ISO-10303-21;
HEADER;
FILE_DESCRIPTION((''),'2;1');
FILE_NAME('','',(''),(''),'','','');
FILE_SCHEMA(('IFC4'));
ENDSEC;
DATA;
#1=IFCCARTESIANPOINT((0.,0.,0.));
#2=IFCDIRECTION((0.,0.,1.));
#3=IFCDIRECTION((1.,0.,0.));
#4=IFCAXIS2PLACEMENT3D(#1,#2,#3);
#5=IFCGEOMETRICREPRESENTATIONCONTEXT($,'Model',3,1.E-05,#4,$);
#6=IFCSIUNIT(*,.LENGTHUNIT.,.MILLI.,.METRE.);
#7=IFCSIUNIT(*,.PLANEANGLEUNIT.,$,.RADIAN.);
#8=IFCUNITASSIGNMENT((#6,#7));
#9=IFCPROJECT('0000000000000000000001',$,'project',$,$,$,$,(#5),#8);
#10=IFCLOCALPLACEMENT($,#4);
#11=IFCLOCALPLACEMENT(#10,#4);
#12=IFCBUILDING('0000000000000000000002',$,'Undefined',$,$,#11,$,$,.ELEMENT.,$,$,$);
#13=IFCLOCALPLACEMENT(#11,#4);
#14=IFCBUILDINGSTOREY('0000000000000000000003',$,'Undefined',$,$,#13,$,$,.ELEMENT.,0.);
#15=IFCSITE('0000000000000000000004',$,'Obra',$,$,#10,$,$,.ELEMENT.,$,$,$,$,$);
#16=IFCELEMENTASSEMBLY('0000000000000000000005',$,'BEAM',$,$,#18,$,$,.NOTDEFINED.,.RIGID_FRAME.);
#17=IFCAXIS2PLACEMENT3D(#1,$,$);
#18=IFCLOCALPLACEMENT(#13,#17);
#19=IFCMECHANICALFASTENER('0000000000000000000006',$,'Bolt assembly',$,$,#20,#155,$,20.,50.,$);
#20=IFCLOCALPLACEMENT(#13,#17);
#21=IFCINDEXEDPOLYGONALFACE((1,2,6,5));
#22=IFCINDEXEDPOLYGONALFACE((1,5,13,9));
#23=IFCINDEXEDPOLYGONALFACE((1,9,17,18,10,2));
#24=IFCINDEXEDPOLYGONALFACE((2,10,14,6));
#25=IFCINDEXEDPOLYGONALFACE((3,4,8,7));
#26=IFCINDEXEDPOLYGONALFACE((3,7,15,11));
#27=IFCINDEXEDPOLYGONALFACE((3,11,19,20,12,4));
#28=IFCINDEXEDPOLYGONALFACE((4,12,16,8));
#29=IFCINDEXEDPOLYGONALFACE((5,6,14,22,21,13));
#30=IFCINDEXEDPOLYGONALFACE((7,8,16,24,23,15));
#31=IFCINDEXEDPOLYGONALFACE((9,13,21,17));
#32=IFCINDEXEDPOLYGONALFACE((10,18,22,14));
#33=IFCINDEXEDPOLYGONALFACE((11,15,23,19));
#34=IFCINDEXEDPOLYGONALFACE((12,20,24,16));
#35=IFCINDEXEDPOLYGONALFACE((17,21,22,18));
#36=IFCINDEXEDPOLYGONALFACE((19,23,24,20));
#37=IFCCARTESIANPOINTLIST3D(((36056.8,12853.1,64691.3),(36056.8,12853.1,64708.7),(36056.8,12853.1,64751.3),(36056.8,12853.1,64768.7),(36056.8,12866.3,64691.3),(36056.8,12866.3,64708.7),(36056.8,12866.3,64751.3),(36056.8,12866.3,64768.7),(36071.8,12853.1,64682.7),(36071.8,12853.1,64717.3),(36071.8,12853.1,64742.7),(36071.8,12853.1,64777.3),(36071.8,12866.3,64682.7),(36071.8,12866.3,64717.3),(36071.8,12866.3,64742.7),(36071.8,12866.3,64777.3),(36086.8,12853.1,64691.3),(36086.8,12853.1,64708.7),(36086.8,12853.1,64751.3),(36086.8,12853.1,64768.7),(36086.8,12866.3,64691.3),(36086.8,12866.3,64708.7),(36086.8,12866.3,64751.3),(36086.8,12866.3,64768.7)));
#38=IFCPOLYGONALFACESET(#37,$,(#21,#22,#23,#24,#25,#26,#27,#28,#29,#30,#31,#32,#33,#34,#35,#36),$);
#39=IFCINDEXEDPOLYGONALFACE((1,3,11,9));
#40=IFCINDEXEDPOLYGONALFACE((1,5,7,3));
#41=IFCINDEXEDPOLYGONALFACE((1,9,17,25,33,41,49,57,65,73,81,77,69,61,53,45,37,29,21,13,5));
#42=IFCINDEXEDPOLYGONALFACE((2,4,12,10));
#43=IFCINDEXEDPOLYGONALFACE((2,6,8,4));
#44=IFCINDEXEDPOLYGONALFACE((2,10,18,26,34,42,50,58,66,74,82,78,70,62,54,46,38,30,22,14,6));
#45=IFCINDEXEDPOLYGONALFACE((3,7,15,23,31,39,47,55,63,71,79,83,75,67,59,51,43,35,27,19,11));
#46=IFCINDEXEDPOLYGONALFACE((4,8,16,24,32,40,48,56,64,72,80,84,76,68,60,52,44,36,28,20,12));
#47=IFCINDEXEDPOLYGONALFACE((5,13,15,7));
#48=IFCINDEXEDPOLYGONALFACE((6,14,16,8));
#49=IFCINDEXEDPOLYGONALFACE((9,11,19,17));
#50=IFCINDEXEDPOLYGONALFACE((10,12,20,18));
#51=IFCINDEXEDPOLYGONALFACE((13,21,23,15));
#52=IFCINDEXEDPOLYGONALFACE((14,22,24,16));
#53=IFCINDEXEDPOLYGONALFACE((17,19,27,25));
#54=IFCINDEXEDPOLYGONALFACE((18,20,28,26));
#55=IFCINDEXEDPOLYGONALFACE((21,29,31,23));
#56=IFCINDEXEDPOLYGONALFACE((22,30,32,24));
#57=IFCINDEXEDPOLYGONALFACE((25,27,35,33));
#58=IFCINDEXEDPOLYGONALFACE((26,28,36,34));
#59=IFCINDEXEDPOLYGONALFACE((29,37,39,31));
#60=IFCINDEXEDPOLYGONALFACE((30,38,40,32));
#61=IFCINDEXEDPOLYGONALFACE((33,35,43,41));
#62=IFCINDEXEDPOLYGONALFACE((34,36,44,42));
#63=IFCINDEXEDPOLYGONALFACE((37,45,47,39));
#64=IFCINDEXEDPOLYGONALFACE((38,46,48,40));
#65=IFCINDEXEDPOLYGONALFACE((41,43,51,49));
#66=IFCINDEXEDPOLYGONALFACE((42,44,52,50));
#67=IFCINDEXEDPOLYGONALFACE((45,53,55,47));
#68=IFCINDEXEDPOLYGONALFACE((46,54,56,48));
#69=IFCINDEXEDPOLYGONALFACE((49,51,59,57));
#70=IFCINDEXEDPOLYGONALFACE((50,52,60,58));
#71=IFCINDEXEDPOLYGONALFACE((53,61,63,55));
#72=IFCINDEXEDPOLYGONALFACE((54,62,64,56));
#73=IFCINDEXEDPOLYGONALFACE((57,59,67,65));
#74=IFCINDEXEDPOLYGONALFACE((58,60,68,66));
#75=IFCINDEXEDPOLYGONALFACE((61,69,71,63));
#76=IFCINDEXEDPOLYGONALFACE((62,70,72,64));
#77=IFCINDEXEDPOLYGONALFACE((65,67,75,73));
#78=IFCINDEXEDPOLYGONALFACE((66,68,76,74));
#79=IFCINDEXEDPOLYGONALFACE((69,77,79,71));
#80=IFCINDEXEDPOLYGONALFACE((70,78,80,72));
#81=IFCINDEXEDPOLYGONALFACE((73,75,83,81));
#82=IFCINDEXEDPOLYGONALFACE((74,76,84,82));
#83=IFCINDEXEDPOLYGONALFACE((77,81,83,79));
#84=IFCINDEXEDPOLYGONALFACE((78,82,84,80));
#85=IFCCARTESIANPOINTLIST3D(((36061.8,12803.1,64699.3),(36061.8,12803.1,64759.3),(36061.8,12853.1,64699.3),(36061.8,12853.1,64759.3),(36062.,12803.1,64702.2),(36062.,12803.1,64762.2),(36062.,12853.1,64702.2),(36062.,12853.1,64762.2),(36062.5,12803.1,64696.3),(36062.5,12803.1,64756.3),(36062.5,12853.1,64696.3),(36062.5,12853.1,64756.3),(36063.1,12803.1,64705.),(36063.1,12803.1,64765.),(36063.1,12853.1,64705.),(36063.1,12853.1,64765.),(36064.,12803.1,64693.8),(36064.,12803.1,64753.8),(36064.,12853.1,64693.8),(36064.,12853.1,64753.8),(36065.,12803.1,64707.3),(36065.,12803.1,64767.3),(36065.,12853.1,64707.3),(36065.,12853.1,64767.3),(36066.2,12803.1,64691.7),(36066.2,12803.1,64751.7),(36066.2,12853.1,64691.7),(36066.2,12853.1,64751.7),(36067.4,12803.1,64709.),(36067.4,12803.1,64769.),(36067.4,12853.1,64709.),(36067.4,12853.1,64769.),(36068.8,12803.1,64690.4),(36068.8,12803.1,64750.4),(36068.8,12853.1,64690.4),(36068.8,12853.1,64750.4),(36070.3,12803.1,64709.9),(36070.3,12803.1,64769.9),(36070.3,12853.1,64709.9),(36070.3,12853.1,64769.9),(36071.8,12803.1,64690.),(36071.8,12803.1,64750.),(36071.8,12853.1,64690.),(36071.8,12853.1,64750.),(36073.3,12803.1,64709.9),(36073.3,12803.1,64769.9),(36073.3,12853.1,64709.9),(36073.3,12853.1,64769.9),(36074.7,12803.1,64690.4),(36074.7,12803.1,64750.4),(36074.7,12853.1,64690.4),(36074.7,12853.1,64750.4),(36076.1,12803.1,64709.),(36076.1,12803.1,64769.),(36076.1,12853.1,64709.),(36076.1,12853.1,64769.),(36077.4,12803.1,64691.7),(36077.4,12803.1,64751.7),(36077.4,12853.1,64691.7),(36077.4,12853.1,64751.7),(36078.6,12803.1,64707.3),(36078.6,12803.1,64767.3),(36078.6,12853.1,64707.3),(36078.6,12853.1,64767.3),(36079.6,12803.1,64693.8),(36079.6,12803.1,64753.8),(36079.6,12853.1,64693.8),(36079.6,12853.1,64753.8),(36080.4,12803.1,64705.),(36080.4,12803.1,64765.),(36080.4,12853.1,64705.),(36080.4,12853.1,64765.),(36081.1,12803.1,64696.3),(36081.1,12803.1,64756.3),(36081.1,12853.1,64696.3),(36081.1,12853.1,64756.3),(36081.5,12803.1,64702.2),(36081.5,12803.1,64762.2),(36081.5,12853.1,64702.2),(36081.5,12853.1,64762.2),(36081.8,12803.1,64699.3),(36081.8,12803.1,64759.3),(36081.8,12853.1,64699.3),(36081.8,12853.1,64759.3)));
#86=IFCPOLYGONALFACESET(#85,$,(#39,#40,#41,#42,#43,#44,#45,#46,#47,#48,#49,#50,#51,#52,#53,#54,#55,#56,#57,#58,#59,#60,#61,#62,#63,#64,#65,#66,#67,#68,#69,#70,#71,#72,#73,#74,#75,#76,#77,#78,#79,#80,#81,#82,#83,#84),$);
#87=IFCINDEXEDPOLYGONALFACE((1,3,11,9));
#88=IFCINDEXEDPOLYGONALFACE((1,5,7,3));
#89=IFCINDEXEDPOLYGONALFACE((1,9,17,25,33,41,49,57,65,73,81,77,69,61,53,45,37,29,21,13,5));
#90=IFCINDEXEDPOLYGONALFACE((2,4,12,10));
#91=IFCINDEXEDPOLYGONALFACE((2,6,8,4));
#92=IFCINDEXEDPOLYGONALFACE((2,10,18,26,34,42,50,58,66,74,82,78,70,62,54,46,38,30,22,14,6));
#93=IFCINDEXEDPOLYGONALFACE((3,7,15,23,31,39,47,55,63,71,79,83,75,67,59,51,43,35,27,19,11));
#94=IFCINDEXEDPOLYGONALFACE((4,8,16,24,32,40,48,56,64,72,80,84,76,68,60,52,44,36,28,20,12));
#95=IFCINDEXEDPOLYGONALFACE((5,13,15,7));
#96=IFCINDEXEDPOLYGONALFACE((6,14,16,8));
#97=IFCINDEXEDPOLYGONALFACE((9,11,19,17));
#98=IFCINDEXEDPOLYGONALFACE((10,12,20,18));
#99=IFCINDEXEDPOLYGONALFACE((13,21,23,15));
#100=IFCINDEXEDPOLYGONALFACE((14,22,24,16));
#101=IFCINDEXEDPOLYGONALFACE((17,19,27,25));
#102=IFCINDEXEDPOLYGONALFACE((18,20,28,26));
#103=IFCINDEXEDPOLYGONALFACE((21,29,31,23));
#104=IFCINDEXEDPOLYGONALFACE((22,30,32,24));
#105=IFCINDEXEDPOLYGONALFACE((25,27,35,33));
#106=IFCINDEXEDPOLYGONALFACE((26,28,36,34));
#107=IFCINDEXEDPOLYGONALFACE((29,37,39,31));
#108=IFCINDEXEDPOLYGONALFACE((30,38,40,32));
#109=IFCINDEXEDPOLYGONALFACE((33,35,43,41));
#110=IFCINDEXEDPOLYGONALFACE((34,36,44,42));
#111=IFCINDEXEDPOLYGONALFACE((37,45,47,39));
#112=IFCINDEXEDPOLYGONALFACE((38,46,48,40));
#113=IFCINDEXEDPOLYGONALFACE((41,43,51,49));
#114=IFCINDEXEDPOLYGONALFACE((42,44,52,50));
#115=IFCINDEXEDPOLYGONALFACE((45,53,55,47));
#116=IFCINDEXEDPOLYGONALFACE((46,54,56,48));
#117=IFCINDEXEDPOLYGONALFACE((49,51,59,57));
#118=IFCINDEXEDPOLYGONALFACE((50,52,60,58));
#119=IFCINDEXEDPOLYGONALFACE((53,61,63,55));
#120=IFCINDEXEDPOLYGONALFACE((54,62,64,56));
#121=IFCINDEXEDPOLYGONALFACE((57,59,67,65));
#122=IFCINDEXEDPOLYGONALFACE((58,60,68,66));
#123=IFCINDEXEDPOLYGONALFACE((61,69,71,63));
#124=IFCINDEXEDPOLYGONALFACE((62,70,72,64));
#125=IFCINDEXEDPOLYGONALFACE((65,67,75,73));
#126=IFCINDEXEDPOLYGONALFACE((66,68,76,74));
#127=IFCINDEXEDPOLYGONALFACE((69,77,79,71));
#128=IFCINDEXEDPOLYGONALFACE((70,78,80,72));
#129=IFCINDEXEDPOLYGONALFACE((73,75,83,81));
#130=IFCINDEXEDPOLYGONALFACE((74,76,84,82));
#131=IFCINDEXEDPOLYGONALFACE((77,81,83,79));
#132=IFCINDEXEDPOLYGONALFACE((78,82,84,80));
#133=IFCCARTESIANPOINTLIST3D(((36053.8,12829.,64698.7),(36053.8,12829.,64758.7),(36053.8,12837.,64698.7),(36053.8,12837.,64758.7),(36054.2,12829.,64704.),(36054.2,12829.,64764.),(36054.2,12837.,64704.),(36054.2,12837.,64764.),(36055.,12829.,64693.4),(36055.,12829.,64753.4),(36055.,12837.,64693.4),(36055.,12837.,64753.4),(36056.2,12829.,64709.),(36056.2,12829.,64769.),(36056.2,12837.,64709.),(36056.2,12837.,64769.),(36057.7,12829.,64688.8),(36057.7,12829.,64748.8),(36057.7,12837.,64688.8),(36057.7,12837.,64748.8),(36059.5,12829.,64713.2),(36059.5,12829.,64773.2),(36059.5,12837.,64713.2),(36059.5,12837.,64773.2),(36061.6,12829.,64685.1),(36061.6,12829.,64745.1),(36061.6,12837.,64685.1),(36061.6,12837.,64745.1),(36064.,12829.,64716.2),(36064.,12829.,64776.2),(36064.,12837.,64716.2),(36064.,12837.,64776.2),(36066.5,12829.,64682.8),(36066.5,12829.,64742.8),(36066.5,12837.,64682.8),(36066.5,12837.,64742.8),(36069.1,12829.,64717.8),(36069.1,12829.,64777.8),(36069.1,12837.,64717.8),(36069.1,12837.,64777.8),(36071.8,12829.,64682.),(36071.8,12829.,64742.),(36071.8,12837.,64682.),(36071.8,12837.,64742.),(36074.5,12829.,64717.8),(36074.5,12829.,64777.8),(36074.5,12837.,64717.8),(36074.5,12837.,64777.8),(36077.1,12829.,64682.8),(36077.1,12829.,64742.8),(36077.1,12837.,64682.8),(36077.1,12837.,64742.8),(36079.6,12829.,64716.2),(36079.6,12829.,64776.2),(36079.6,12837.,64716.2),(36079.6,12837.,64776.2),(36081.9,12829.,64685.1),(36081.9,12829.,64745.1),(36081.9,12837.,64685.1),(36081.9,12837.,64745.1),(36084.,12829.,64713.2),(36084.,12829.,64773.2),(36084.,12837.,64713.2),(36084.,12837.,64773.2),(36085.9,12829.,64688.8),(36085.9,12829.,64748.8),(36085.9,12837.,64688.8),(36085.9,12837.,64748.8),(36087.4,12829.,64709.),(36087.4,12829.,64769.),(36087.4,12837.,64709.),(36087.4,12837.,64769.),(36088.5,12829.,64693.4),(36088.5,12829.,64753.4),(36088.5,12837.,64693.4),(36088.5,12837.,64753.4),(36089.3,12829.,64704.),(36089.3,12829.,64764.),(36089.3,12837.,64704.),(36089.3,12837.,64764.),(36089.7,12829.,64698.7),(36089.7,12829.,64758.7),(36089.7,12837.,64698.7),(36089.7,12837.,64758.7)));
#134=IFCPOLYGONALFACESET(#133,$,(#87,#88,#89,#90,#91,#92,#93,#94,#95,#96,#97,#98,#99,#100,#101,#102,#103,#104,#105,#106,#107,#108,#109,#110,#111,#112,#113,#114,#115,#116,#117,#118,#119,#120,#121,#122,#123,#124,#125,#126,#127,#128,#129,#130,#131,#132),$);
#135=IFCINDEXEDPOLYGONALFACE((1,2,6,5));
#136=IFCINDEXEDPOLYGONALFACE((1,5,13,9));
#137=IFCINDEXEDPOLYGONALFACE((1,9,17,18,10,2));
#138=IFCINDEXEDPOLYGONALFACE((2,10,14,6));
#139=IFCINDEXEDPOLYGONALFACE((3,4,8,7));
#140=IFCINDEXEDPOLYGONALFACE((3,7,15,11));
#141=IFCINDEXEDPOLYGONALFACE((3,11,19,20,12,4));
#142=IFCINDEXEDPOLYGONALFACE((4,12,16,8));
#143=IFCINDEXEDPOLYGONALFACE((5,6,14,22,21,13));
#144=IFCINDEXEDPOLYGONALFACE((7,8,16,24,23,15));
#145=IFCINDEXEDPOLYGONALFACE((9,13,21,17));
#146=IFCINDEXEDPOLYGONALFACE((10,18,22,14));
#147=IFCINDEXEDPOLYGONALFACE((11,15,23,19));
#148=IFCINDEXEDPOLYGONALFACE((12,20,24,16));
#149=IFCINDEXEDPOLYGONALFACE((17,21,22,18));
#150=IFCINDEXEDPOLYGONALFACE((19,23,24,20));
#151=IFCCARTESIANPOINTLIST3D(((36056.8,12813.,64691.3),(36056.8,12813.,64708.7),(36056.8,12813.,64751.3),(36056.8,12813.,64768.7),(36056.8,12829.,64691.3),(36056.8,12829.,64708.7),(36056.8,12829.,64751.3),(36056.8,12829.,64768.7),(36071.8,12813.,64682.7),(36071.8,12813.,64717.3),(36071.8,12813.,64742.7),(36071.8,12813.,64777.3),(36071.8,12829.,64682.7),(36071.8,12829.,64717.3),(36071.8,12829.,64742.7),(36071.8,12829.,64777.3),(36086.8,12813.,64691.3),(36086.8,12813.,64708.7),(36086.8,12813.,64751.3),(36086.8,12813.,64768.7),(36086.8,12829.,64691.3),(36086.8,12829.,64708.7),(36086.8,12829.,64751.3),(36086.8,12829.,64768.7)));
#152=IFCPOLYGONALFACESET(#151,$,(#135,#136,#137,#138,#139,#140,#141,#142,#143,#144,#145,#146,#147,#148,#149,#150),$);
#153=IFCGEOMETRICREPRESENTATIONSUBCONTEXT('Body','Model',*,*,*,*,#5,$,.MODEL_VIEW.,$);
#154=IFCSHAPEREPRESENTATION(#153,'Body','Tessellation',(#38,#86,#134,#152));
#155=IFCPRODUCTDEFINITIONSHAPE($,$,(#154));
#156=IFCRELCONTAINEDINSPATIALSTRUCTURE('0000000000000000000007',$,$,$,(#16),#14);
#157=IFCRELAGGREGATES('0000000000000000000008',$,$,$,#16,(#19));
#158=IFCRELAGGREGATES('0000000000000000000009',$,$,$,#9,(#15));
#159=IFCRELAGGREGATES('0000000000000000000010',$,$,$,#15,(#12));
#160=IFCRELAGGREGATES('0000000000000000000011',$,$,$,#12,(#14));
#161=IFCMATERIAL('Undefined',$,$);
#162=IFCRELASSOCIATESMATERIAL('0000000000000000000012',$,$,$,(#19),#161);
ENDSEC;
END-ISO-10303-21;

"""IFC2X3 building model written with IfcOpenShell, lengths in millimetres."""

from ifc_helpers import new_model, si_unit, frame, origin_with_axes, origin_2d_with_axis, place, context, subcontext, project, spatial, polyline, circle, outline, extrude, source, transform, mapped, material, element, aggregate, save


model = new_model("IFC2X3")

# Units and contexts
model_context = context("Model", 3, precision=1e-05, world=origin_with_axes())
body_context = subcontext(model_context, "Body", "Model", "MODEL_VIEW")
ifc_project = project(units=[si_unit("LENGTHUNIT", "METRE", prefix="MILLI"), si_unit("PLANEANGLEUNIT", "RADIAN")], contexts=[model_context])

# Site, building, storey
site_placement = place(None, origin_with_axes())
site = spatial("IfcSite", under=ifc_project, at=site_placement, Name="Obra", CompositionType="ELEMENT")
building_placement = place(site_placement, origin_with_axes())
building = spatial("IfcBuilding", under=site, at=building_placement, Name="Undefined", CompositionType="ELEMENT")
storey_placement = place(building_placement, origin_with_axes())
storey = spatial("IfcBuildingStorey", under=building, at=storey_placement, Name="Undefined", CompositionType="ELEMENT", Elevation=0.0)

# Shared definitions
ifc_material = material(Name="Undefined")

# Element assembly, mechanical fastener
assembly_1_placement = place(storey_placement, origin_with_axes())
assembly_1 = element("IfcElementAssembly", 1, at=assembly_1_placement, inside=storey, Name="BEAM", AssemblyPlace="NOTDEFINED", PredefinedType="RIGID_FRAME")
shared_shape_1 = source(origin_with_axes(), body_context, "Body", "SweptSolid", [
    extrude(outline(polyline([(17.3, 0.0), (8.7, 15.0), (-8.7, 15.0), (-17.3, 0.0), (-8.7, -15.0), (8.7, -15.0), (17.3, 0.0)])), frame((0.0, -26.3, 0.0), z_axis=(0.0, 1.0, 0.0), x_axis=(1.0, 0.0, 0.0)), (0.0, 0.0, 1.0), 13.2),
    extrude(circle(Radius=10.0, at=origin_2d_with_axis()), frame((0.0, -13.1, 0.0), z_axis=(0.0, 1.0, 0.0), x_axis=(1.0, 0.0, 0.0)), (0.0, 0.0, 1.0), 50.0),
    extrude(circle(Radius=18.0, at=origin_2d_with_axis()), frame((0.0, 3.0, 0.0), z_axis=(0.0, 1.0, 0.0), x_axis=(1.0, 0.0, 0.0)), (0.0, 0.0, 1.0), 8.0),
    extrude(outline(polyline([(17.3, 0.0), (8.7, 15.0), (-8.7, 15.0), (-17.3, 0.0), (-8.7, -15.0), (8.7, -15.0), (17.3, 0.0)])), frame((0.0, 11.0, 0.0), z_axis=(0.0, 1.0, 0.0), x_axis=(1.0, 0.0, 0.0)), (0.0, 0.0, 1.0), 16.0),
])
mechanical_fastener_1_placement = place(assembly_1_placement, frame((36111.8, 12840.0, 64850.0), z_axis=(-1.0, 0.0, 0.0), x_axis=(0.0, 0.0, -1.0)))
mechanical_fastener_1 = element("IfcMechanicalFastener", 2, at=mechanical_fastener_1_placement, material=ifc_material, Name="Bolt assembly", NominalDiameter=20.0, NominalLength=50.0, context=body_context, shape_type="MappedRepresentation", body=[
    mapped(shared_shape_1, transform((90.0, 0.0, 40.0))),
    mapped(shared_shape_1, transform((150.0, 0.0, 40.0))),
])

aggregate(assembly_1, [mechanical_fastener_1])

save(model, "model.ifc")
